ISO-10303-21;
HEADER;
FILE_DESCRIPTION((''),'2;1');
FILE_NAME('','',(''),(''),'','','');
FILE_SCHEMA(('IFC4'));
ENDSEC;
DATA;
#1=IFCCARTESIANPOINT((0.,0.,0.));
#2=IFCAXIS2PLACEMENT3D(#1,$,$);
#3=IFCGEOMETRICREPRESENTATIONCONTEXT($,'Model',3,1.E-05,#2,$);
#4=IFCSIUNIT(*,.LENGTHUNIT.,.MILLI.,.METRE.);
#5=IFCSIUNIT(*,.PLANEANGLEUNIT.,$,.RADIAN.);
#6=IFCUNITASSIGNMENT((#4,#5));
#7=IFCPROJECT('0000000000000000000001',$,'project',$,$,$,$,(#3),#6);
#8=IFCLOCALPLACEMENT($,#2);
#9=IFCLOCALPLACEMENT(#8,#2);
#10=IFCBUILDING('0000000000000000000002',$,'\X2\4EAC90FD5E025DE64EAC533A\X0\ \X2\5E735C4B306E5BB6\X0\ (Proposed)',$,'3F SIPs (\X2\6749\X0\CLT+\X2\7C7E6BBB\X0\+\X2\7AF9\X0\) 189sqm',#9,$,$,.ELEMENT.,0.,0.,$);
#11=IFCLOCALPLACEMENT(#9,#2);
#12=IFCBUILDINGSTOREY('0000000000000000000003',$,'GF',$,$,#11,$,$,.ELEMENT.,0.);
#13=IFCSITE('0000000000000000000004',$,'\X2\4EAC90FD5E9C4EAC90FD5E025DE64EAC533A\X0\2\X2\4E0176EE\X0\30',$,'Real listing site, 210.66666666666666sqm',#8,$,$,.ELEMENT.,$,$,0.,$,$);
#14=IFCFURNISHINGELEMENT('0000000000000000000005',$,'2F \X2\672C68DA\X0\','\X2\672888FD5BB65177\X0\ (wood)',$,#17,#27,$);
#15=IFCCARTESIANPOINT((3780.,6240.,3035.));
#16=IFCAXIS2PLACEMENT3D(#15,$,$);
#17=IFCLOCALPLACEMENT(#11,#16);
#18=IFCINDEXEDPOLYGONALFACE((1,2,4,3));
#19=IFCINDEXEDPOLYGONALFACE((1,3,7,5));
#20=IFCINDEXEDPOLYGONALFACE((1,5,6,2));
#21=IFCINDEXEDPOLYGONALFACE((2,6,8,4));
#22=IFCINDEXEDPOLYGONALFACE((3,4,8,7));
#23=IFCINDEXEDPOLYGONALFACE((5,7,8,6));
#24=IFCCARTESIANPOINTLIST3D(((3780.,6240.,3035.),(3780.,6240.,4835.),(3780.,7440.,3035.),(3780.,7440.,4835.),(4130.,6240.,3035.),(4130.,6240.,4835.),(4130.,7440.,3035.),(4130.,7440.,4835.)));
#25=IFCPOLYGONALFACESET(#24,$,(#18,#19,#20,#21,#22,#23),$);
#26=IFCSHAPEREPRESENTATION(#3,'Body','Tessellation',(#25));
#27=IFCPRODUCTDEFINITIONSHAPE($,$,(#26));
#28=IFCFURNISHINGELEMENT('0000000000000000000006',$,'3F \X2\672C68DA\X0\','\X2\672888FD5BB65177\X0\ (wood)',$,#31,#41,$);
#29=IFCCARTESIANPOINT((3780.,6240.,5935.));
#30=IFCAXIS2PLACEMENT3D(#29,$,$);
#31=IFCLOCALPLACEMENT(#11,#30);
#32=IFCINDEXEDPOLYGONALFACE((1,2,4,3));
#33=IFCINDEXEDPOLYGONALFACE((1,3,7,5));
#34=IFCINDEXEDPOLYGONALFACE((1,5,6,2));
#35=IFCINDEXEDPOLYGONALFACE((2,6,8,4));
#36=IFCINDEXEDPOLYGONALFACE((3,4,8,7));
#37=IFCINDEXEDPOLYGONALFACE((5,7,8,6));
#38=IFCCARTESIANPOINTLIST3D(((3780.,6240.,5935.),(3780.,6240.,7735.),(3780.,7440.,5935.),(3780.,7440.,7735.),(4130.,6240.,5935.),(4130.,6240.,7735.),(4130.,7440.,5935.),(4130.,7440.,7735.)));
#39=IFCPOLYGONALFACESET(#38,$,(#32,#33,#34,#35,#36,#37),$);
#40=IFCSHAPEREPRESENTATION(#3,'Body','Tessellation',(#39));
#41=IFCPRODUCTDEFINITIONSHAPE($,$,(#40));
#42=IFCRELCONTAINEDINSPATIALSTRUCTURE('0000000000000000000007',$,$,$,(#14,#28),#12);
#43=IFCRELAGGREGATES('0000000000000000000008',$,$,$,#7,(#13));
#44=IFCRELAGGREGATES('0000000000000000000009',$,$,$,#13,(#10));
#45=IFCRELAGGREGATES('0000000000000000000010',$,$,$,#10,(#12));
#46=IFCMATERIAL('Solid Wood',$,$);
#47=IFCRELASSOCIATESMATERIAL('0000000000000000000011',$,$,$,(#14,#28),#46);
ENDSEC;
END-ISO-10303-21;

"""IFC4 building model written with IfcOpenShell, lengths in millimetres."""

from ifc_helpers import new_model, si_unit, frame, frame_2d, origin, place, context, project, spatial, rectangle, extrude, material, element, save


model = new_model("IFC4")

# Units and contexts
model_context = context("Model", 3, precision=1e-05, world=origin())
ifc_project = project(units=[si_unit("LENGTHUNIT", "METRE", prefix="MILLI"), si_unit("PLANEANGLEUNIT", "RADIAN")], contexts=[model_context])

# Site, building, storey
site_placement = place(None, origin())
site = spatial("IfcSite", under=ifc_project, at=site_placement, Name="京都府京都市左京区2丁目30", ObjectType="Real listing site, 210.66666666666666sqm", CompositionType="ELEMENT", RefElevation=0.0)
building_placement = place(site_placement, origin())
building = spatial("IfcBuilding", under=site, at=building_placement, Name="京都市左京区 平屋の家 (Proposed)", ObjectType="3F SIPs (杉CLT+籾殻+竹) 189sqm", CompositionType="ELEMENT", ElevationOfRefHeight=0.0, ElevationOfTerrain=0.0)
storey_placement = place(building_placement, origin())
storey = spatial("IfcBuildingStorey", under=building, at=storey_placement, Name="GF", CompositionType="ELEMENT", Elevation=0.0)

# Shared definitions
ifc_material_1 = material(Name="Solid Wood")

# Furnishing elements
furnishing_1_placement = place(storey_placement, frame((3780.0, 6240.0, 3035.0)))
element("IfcFurnishingElement", 1, at=furnishing_1_placement, inside=storey, material=ifc_material_1, Name="2F 本棚", Description="木製家具 (wood)", context=model_context, shape_type="SweptSolid", body=[
    extrude(rectangle(XDim=350.0, YDim=1200.0, at=frame_2d((175.0, 600.0))), frame((3780.0, 6240.0, 3035.0)), (0.0, 0.0, 1.0), 1800.0),
])
furnishing_2_placement = place(storey_placement, frame((3780.0, 6240.0, 5935.0)))
element("IfcFurnishingElement", 2, at=furnishing_2_placement, inside=storey, material=ifc_material_1, Name="3F 本棚", Description="木製家具 (wood)", context=model_context, shape_type="SweptSolid", body=[
    extrude(rectangle(XDim=350.0, YDim=1200.0, at=frame_2d((175.0, 600.0))), frame((3780.0, 6240.0, 5935.0)), (0.0, 0.0, 1.0), 1800.0),
])

save(model, "model.ifc")
